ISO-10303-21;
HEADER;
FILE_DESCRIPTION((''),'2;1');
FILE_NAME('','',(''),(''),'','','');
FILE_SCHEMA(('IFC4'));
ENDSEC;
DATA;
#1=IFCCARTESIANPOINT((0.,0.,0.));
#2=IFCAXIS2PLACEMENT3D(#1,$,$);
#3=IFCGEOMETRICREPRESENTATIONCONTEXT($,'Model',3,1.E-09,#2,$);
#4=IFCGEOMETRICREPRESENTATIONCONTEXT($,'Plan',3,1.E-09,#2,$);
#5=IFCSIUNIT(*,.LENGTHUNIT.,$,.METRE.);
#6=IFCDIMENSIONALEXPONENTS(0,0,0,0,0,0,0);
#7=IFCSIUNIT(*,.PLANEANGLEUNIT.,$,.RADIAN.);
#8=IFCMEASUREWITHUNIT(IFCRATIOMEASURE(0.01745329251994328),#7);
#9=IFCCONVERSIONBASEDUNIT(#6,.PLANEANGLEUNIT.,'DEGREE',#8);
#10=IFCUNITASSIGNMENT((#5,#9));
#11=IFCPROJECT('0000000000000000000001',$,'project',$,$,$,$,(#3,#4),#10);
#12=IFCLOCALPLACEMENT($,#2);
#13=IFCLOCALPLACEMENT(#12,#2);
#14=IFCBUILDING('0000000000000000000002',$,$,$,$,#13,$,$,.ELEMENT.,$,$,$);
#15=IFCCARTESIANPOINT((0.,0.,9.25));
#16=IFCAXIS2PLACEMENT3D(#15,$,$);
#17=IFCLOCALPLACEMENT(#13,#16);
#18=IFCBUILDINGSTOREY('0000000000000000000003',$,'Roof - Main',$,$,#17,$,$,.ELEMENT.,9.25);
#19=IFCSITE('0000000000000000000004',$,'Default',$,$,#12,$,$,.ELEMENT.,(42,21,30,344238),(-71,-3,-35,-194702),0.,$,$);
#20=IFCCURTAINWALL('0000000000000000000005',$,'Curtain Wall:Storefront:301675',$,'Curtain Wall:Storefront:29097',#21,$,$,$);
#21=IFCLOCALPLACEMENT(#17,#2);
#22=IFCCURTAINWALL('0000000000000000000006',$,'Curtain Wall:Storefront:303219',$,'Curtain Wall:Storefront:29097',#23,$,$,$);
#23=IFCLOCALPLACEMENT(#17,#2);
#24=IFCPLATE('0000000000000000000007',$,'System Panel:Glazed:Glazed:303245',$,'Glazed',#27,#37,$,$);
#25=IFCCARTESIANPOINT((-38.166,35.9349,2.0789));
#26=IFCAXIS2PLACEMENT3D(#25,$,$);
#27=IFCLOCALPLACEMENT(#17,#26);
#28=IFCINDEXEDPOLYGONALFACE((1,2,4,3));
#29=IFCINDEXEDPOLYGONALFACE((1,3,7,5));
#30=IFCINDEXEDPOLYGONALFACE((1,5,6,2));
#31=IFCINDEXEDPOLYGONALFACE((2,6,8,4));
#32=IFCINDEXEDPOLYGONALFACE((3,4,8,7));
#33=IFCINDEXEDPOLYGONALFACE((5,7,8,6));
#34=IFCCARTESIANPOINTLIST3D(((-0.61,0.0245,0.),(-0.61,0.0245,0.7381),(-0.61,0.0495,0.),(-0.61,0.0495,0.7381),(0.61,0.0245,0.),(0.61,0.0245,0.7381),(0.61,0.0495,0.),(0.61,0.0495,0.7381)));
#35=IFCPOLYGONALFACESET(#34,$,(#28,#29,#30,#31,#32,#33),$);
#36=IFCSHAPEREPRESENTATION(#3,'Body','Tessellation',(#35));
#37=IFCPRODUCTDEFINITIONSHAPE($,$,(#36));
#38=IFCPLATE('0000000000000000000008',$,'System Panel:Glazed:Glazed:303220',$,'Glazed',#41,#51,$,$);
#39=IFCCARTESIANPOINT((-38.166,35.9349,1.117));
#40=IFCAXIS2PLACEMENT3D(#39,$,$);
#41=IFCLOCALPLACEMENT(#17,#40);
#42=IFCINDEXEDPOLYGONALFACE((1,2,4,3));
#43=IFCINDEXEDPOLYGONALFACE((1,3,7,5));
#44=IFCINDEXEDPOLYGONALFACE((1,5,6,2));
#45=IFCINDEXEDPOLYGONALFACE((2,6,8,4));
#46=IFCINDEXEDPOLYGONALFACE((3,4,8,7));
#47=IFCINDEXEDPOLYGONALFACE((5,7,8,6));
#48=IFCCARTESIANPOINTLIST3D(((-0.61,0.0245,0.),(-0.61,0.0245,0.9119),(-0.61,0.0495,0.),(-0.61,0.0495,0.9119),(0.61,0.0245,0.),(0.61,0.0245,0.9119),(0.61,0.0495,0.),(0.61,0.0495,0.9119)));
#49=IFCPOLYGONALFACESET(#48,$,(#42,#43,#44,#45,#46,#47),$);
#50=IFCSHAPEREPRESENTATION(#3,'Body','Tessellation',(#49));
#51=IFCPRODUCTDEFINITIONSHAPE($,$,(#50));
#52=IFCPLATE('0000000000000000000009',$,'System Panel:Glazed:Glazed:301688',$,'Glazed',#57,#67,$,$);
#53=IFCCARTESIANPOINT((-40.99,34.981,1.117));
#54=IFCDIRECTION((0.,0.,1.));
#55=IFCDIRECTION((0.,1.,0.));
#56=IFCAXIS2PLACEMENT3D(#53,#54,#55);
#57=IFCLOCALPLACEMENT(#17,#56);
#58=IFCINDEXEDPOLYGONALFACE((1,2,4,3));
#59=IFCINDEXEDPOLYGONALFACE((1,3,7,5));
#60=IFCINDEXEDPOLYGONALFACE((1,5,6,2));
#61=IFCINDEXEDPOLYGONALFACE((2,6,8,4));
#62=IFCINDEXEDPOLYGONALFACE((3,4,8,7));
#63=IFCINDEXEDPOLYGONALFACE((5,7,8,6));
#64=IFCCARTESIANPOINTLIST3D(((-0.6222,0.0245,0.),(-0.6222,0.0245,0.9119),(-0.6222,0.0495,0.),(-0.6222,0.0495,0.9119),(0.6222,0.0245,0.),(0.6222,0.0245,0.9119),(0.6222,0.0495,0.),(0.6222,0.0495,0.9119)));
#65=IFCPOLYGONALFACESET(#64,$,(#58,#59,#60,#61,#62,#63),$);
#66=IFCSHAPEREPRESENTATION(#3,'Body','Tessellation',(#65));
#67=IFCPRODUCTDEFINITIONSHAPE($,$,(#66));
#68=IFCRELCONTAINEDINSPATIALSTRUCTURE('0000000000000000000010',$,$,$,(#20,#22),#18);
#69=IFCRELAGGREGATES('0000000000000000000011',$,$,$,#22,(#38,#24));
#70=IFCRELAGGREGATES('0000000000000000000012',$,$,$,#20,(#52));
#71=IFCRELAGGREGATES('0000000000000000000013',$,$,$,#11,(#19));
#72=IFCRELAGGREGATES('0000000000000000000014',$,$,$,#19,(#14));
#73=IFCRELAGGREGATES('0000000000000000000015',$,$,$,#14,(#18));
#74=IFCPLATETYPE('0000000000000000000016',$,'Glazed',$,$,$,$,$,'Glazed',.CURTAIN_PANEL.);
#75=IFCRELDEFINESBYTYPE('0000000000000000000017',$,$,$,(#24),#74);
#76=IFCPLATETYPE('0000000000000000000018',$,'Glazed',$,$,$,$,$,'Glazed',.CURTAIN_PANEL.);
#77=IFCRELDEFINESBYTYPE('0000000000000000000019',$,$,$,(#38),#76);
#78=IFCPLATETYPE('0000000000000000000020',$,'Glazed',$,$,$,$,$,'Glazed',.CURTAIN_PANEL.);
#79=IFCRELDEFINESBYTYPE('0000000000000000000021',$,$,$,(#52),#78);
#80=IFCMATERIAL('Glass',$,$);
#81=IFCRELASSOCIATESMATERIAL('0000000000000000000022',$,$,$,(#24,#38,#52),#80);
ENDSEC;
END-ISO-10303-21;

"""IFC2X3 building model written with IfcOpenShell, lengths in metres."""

from ifc_helpers import new_model, entity, si_unit, converted_unit, frame, origin, origin_2d_with_axis, place, context, project, spatial, rectangle, extrude, source, transform, mapped, material, type_object, type_shapes, element, aggregate, save


model = new_model("IFC2X3")

# Units and contexts
model_context = context("Model", 3, precision=1e-09, world=origin())
plan_context = context("Plan", 3, precision=1e-09, world=origin())
ifc_project = project(units=[si_unit("LENGTHUNIT", "METRE"), converted_unit("PLANEANGLEUNIT", "DEGREE", entity("IfcRatioMeasure", 0.01745329251994328), si_unit("PLANEANGLEUNIT", "RADIAN"), dimensions=[0, 0, 0, 0, 0, 0, 0])], contexts=[model_context, plan_context])

# Site, building, storey
site_placement = place(None, origin())
site = spatial("IfcSite", under=ifc_project, at=site_placement, Name="Default", CompositionType="ELEMENT", RefLatitude=(42, 21, 30, 344238), RefLongitude=(-71, -3, -35, -194702), RefElevation=0.0)
building_placement = place(site_placement, origin())
building = spatial("IfcBuilding", under=site, at=building_placement, CompositionType="ELEMENT")
storey_placement = place(building_placement, frame((0.0, 0.0, 9.25)))
storey = spatial("IfcBuildingStorey", under=building, at=storey_placement, Name="Roof - Main", CompositionType="ELEMENT", Elevation=9.25)

# Curtain wall
curtain_wall_1_placement = place(storey_placement, origin())
curtain_wall_1 = element("IfcCurtainWall", 1, at=curtain_wall_1_placement, inside=storey, Name="Curtain Wall:Storefront:301675", ObjectType="Curtain Wall:Storefront:29097")

# Curtain wall
curtain_wall_2_placement = place(storey_placement, origin())
curtain_wall_2 = element("IfcCurtainWall", 2, at=curtain_wall_2_placement, inside=storey, Name="Curtain Wall:Storefront:303219", ObjectType="Curtain Wall:Storefront:29097")

# Plates
ifc_material_1 = material(Name="Glass")
plate_type_1 = type_object("IfcPlateType", Name="Glazed", ElementType="Glazed", PredefinedType="CURTAIN_PANEL")
shared_shape_1 = source(origin(), model_context, "Body", "SweptSolid", [
    extrude(rectangle(XDim=0.025, YDim=1.22, at=origin_2d_with_axis()), frame((0.0, 0.037, 0.0), z_axis=(0.0, 0.0, 1.0), x_axis=(0.0, 1.0, 0.0)), (0.0, 0.0, 1.0), 0.7381),
])
type_shapes(plate_type_1, [shared_shape_1])
plate_1_placement = place(storey_placement, frame((-38.166, 35.9349, 2.0789)))
plate_1 = element("IfcPlate", 3, at=plate_1_placement, type_object=plate_type_1, material=ifc_material_1, Name="System Panel:Glazed:Glazed:303245", ObjectType="Glazed", context=model_context, shape_type="MappedRepresentation", body=[
    mapped(shared_shape_1, transform((0.0, 0.0, 0.0), scale=1.0)),
])
plate_type_2 = type_object("IfcPlateType", Name="Glazed", ElementType="Glazed", PredefinedType="CURTAIN_PANEL")
shared_shape_2 = source(origin(), model_context, "Body", "SweptSolid", [
    extrude(rectangle(XDim=0.025, YDim=1.22, at=origin_2d_with_axis()), frame((0.0, 0.037, 0.0), z_axis=(0.0, 0.0, 1.0), x_axis=(0.0, 1.0, 0.0)), (0.0, 0.0, 1.0), 0.9119),
])
type_shapes(plate_type_2, [shared_shape_2])
plate_2_placement = place(storey_placement, frame((-38.166, 35.9349, 1.117)))
plate_2 = element("IfcPlate", 4, at=plate_2_placement, type_object=plate_type_2, material=ifc_material_1, Name="System Panel:Glazed:Glazed:303220", ObjectType="Glazed", context=model_context, shape_type="MappedRepresentation", body=[
    mapped(shared_shape_2, transform((0.0, 0.0, 0.0), scale=1.0)),
])
aggregate(curtain_wall_2, [plate_2, plate_1])
plate_type_3 = type_object("IfcPlateType", Name="Glazed", ElementType="Glazed", PredefinedType="CURTAIN_PANEL")
shared_shape_3 = source(origin(), model_context, "Body", "SweptSolid", [
    extrude(rectangle(XDim=0.025, YDim=1.2444, at=origin_2d_with_axis()), frame((0.0, 0.037, 0.0), z_axis=(0.0, 0.0, 1.0), x_axis=(0.0, 1.0, 0.0)), (0.0, 0.0, 1.0), 0.9119),
])
type_shapes(plate_type_3, [shared_shape_3])
plate_3_placement = place(storey_placement, frame((-40.99, 34.981, 1.117), z_axis=(0.0, 0.0, 1.0), x_axis=(0.0, 1.0, 0.0)))
plate_3 = element("IfcPlate", 5, at=plate_3_placement, type_object=plate_type_3, material=ifc_material_1, Name="System Panel:Glazed:Glazed:301688", ObjectType="Glazed", context=model_context, shape_type="MappedRepresentation", body=[
    mapped(shared_shape_3, transform((0.0, 0.0, 0.0), scale=1.0)),
])
aggregate(curtain_wall_1, [plate_3])

save(model, "model.ifc")
